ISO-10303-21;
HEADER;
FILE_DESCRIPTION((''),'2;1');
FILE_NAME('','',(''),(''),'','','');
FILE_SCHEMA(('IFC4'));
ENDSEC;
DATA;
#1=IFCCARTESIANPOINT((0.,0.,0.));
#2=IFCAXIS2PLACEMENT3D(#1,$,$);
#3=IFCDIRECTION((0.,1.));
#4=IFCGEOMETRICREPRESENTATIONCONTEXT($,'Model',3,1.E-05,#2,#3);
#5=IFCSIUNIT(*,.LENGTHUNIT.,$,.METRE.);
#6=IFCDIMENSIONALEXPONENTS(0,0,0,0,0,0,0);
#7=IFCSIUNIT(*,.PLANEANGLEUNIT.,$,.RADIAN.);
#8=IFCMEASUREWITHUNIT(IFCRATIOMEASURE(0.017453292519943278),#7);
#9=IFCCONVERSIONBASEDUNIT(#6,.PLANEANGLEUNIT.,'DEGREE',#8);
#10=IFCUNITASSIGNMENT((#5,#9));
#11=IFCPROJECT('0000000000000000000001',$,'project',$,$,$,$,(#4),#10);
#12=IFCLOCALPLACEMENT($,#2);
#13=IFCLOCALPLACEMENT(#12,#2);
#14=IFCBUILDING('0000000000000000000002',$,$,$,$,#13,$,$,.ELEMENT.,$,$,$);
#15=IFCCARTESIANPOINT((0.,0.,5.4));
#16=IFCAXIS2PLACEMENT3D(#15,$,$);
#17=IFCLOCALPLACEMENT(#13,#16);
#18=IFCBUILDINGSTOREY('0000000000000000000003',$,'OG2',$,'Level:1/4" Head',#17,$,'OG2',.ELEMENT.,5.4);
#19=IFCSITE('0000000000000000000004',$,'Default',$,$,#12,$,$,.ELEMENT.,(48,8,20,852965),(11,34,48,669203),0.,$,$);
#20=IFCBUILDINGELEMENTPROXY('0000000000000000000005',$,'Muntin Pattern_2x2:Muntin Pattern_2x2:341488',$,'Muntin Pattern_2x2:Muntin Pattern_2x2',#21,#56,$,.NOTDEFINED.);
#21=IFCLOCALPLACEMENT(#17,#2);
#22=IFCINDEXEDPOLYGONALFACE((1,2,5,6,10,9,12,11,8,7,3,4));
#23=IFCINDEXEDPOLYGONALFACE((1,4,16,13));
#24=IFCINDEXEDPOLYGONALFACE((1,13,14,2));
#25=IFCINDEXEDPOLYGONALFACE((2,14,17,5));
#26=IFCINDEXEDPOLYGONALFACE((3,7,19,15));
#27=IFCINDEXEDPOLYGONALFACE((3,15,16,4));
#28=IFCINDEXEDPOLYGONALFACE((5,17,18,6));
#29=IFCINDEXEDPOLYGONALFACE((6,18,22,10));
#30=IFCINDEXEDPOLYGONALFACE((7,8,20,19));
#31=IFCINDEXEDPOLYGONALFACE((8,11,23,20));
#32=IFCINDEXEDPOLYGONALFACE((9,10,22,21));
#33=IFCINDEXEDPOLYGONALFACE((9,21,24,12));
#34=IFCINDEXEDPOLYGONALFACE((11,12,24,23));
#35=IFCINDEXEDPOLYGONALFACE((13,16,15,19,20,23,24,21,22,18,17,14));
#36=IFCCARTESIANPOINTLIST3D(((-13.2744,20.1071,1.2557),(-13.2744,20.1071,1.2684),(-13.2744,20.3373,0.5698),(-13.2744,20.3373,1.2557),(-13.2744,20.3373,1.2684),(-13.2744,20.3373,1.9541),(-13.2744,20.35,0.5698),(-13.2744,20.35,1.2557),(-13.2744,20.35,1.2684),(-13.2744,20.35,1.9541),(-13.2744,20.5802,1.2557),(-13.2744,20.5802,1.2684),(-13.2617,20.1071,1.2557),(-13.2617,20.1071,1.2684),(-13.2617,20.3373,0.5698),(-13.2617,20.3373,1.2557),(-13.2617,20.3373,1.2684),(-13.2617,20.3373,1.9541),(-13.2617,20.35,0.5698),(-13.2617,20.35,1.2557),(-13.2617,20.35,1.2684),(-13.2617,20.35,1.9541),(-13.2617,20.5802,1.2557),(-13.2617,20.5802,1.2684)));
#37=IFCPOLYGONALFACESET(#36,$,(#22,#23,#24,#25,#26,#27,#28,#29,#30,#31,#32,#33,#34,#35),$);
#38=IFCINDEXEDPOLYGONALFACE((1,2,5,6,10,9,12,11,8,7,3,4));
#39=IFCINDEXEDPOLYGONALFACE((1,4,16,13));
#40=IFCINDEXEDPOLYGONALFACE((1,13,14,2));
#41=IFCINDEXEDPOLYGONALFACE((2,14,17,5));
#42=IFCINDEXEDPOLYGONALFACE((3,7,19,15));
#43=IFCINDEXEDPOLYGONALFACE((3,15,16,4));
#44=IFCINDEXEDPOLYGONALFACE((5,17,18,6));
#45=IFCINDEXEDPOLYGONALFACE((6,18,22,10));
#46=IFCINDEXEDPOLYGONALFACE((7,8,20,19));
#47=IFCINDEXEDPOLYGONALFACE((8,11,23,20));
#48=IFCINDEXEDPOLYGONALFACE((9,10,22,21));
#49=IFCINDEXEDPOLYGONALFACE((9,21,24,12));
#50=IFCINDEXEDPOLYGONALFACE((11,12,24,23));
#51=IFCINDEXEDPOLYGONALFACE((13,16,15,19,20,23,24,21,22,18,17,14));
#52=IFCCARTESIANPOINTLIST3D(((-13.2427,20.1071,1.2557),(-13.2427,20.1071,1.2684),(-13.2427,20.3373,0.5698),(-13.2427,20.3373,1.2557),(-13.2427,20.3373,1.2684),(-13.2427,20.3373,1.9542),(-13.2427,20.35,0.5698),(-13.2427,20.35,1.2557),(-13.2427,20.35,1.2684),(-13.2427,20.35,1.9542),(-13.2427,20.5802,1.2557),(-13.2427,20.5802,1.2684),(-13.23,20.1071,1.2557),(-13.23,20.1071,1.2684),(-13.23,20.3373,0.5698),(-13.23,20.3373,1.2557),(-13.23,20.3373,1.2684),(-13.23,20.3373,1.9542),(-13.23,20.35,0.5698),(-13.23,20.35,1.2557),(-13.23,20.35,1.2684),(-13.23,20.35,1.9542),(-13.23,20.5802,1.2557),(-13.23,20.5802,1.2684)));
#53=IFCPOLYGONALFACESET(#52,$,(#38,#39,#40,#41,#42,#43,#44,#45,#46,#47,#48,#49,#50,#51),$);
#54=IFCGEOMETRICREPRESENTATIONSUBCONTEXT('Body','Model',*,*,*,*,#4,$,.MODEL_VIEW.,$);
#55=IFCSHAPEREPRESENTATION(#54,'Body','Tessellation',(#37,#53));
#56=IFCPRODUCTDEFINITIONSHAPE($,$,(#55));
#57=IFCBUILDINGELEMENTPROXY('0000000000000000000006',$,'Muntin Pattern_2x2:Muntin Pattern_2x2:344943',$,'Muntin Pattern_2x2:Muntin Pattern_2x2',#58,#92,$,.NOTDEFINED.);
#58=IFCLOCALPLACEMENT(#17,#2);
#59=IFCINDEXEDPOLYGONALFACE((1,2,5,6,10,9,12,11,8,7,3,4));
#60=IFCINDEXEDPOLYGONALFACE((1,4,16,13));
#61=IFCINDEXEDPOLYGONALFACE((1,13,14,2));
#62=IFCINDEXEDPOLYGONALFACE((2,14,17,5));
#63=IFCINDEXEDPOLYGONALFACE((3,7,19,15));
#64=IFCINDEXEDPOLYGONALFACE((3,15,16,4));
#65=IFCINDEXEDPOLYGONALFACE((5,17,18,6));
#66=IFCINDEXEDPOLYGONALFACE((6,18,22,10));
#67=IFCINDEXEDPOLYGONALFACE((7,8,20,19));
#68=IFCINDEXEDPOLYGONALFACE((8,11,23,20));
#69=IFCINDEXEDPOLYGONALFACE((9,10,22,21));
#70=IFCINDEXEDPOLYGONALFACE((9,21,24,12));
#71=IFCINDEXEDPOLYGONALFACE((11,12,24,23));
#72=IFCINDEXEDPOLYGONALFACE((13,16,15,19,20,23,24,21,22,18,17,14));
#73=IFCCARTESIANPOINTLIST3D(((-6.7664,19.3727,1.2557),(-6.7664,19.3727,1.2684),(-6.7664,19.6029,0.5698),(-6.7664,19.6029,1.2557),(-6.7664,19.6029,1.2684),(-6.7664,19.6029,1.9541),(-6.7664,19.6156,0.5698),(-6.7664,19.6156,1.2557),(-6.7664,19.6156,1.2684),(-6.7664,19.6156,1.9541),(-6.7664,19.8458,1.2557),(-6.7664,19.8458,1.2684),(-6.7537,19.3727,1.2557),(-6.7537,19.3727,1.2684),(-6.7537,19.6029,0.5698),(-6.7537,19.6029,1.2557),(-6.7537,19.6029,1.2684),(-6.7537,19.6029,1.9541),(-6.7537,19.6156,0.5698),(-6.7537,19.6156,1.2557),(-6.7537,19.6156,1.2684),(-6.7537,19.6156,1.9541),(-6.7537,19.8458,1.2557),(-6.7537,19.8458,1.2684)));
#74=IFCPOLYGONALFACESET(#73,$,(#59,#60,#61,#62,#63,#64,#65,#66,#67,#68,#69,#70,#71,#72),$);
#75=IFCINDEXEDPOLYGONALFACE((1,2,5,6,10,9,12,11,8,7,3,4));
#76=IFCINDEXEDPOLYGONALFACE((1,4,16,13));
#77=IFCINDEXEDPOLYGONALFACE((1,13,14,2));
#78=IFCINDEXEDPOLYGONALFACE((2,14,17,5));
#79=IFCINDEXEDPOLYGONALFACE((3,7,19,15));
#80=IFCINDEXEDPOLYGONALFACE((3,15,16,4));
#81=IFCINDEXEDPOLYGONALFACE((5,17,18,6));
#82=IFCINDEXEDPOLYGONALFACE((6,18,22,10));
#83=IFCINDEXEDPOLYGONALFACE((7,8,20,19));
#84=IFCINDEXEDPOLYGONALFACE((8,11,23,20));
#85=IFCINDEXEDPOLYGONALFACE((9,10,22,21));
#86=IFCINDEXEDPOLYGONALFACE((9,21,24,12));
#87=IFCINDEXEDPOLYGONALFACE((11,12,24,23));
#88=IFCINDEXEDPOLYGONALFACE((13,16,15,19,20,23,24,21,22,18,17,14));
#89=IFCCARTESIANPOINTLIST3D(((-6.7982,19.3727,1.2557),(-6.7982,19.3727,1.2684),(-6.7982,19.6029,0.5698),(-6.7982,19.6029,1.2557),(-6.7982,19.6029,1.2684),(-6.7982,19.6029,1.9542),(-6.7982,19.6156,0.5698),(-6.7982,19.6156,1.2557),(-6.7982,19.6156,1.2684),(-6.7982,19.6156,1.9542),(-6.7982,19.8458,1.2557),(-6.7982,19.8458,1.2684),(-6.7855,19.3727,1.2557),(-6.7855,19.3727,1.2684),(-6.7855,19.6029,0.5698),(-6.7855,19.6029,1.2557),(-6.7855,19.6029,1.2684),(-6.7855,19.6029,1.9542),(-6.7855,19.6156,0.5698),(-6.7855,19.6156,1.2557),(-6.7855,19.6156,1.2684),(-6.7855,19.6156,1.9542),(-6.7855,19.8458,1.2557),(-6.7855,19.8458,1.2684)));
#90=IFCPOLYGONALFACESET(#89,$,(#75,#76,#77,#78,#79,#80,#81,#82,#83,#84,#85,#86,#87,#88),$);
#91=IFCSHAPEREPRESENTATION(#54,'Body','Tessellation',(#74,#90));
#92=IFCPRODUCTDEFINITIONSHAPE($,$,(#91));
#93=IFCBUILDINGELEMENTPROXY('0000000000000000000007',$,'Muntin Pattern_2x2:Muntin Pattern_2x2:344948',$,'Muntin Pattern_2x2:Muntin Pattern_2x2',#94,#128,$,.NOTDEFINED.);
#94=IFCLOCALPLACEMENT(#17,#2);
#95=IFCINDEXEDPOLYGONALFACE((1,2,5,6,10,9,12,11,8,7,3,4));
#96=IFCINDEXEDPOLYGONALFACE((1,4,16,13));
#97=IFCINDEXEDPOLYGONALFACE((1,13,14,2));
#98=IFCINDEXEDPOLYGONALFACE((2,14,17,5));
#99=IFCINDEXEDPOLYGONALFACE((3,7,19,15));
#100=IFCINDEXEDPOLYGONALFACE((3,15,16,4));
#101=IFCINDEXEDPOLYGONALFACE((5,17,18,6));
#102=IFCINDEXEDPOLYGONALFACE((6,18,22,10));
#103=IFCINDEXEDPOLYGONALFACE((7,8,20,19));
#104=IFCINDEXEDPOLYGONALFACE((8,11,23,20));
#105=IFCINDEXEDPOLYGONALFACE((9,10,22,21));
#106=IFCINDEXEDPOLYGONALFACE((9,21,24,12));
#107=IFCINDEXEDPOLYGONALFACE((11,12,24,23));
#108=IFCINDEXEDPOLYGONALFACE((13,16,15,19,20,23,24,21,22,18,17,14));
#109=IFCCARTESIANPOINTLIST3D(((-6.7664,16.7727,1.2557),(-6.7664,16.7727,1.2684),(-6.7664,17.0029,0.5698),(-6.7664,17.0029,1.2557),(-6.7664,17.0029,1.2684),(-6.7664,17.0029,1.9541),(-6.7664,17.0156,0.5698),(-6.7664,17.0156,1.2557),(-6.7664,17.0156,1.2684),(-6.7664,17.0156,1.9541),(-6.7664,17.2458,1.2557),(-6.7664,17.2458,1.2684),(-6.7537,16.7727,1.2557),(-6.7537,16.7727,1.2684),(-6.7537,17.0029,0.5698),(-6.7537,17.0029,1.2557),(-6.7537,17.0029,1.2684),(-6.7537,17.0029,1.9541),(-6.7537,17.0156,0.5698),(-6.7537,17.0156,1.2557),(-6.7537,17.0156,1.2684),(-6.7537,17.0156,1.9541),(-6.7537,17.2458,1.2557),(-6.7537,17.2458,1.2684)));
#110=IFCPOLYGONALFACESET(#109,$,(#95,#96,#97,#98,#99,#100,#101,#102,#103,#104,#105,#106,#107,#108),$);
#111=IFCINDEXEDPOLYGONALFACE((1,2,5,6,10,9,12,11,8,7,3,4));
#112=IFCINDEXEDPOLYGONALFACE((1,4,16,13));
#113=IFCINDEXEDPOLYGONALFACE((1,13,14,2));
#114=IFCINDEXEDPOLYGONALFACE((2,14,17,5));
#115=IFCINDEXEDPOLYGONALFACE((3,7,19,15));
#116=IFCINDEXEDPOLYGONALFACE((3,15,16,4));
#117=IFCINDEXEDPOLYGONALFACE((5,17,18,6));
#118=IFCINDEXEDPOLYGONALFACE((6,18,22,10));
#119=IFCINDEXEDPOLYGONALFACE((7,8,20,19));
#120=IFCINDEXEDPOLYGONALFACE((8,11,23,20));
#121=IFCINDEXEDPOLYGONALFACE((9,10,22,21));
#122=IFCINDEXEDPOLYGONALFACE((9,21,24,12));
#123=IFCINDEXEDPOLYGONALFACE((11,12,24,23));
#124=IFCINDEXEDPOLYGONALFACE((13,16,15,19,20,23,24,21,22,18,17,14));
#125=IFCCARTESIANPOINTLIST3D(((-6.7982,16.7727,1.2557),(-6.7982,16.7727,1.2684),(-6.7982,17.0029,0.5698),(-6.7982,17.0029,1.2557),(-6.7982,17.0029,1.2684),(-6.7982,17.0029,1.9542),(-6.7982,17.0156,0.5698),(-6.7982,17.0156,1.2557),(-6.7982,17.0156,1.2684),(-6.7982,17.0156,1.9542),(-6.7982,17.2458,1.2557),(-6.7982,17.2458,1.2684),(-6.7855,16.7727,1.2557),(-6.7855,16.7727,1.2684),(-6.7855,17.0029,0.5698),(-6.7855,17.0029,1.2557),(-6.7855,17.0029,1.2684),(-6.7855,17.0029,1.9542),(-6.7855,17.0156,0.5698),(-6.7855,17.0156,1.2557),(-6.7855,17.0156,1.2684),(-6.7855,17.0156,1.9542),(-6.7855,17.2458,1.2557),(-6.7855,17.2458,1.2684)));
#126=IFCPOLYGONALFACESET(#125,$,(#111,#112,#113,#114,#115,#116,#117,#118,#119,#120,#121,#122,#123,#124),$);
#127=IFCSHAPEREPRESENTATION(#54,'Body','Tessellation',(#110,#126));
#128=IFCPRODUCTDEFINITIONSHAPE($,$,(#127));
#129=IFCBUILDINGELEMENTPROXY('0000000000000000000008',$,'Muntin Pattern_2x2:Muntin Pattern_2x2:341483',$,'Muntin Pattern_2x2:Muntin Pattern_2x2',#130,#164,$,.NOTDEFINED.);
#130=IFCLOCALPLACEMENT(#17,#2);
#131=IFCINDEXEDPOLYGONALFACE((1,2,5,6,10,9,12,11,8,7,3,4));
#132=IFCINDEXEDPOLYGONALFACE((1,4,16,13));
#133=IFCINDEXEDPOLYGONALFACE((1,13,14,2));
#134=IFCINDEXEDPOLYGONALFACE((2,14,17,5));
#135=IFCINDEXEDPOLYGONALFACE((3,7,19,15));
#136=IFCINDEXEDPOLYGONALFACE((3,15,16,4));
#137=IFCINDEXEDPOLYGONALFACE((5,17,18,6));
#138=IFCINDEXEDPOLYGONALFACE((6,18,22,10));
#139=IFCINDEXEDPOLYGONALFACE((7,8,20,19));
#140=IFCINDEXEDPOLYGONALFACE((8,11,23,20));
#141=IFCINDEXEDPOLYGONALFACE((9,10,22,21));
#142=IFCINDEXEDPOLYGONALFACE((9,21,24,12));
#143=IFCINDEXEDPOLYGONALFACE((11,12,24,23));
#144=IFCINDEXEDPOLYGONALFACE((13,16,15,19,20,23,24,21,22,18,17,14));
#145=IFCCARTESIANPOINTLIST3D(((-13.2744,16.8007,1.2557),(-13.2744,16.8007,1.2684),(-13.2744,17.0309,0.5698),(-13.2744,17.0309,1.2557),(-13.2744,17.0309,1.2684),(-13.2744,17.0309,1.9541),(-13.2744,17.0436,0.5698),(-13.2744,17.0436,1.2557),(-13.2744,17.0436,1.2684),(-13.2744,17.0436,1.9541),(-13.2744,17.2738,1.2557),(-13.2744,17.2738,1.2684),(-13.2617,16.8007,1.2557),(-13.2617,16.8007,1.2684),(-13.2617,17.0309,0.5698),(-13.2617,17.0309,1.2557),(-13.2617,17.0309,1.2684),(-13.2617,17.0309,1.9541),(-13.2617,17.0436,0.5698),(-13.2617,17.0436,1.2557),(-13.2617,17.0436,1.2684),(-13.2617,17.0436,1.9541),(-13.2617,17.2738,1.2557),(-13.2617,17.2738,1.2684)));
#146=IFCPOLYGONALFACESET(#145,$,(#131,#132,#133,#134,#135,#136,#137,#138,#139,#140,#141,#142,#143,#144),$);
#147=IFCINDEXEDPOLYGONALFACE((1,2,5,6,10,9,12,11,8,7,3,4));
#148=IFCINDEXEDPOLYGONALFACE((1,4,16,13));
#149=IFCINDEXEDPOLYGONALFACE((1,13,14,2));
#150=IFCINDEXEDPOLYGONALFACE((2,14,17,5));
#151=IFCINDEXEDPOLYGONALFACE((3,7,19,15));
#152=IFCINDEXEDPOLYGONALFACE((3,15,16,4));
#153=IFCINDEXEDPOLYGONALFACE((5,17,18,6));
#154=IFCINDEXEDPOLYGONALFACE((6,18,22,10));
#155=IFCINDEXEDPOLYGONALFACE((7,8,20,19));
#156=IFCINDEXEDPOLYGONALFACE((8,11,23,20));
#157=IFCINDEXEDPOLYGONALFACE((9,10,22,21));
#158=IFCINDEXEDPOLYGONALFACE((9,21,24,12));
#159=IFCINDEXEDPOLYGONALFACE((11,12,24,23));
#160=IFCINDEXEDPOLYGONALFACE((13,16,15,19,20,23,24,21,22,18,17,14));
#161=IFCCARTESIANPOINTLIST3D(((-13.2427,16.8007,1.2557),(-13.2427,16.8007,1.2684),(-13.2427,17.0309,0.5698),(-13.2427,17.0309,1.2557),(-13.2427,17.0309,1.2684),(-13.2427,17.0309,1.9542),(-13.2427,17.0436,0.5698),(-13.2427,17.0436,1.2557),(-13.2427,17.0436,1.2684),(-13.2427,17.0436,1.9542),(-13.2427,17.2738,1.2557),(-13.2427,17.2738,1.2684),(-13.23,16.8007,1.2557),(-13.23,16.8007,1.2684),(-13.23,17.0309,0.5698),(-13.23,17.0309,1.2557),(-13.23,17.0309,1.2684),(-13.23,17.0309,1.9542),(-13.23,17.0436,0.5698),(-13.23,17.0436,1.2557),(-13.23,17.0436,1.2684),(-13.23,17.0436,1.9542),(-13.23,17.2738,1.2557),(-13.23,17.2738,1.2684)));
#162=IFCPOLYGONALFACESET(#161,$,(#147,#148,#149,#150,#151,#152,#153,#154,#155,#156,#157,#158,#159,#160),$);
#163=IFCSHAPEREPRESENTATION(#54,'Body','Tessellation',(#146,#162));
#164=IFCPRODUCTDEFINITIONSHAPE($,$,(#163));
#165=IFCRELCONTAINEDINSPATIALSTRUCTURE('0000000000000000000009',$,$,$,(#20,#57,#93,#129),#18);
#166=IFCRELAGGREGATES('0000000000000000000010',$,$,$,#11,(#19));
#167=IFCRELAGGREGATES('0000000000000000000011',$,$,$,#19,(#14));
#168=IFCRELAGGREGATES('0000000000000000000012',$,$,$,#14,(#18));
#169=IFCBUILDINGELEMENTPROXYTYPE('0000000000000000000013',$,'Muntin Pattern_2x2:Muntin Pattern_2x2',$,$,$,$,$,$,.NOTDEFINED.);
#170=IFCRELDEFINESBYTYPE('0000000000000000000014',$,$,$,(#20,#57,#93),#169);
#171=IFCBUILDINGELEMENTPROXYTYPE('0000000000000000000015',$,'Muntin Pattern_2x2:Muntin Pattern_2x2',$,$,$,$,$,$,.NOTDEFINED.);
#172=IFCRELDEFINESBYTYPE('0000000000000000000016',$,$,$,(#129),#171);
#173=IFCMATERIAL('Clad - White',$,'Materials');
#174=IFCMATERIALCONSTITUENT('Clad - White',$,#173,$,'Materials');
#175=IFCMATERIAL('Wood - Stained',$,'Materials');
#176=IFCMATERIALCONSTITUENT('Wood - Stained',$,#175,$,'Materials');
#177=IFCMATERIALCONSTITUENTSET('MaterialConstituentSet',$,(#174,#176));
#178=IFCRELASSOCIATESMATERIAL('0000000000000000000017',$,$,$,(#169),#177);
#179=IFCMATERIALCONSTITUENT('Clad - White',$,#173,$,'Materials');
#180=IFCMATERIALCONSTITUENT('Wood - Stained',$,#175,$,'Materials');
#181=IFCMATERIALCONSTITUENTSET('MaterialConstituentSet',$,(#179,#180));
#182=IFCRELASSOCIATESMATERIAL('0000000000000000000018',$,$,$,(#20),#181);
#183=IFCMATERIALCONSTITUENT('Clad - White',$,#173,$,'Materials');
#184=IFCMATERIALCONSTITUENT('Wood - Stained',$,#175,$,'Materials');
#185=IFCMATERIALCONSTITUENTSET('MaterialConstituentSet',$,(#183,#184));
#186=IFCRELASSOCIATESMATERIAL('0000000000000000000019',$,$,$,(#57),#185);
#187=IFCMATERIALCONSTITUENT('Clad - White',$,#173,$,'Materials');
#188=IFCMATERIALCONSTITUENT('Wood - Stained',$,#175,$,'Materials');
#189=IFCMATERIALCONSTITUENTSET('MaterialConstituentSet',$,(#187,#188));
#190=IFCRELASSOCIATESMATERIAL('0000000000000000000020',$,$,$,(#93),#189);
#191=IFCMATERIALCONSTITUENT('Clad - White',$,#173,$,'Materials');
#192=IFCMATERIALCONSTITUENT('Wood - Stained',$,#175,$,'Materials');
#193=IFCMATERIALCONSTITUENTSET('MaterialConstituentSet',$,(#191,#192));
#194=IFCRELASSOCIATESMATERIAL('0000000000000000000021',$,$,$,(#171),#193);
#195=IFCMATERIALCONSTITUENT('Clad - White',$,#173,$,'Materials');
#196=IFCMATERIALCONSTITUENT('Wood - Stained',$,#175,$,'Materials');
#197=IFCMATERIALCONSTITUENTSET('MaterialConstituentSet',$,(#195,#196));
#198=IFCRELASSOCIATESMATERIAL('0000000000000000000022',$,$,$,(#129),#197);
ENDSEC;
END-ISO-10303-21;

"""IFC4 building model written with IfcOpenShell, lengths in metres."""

from ifc_helpers import new_model, entity, si_unit, converted_unit, direction, frame, origin, place, context, subcontext, project, spatial, indexed_curve, outline, extrude, source, transform, mapped, material, constituent, constituent_set, type_object, type_shapes, element, save


model = new_model("IFC4")

# Units and contexts
model_context = context("Model", 3, precision=1e-05, world=origin(), true_north=direction((0.0, 1.0)))
body_context = subcontext(model_context, "Body", "Model", "MODEL_VIEW")
ifc_project = project(units=[si_unit("LENGTHUNIT", "METRE"), converted_unit("PLANEANGLEUNIT", "DEGREE", entity("IfcRatioMeasure", 0.017453292519943278), si_unit("PLANEANGLEUNIT", "RADIAN"), dimensions=[0, 0, 0, 0, 0, 0, 0])], contexts=[model_context])

# Site, building, storey
site_placement = place(None, origin())
site = spatial("IfcSite", under=ifc_project, at=site_placement, Name="Default", CompositionType="ELEMENT", RefLatitude=(48, 8, 20, 852965), RefLongitude=(11, 34, 48, 669203), RefElevation=0.0)
building_placement = place(site_placement, origin())
building = spatial("IfcBuilding", under=site, at=building_placement, CompositionType="ELEMENT")
storey_placement = place(building_placement, frame((0.0, 0.0, 5.4)))
storey = spatial("IfcBuildingStorey", under=building, at=storey_placement, Name="OG2", ObjectType="Level:1/4\" Head", LongName="OG2", CompositionType="ELEMENT", Elevation=5.4)

# Building element proxies
ifc_material_1 = material(Name="Clad - White", Category="Materials")
ifc_material_2 = material(Name="Wood - Stained", Category="Materials")
ifc_constituent_1 = constituent(ifc_material_1, Name="Clad - White", Category="Materials")
ifc_constituent_2 = constituent(ifc_material_2, Name="Wood - Stained", Category="Materials")
ifc_constituent_set_1 = constituent_set(constituents=[ifc_constituent_1, ifc_constituent_2], Name="MaterialConstituentSet")
building_element_proxy_type_1 = type_object("IfcBuildingElementProxyType", Name="Muntin Pattern_2x2:Muntin Pattern_2x2", PredefinedType="NOTDEFINED", material=ifc_constituent_set_1)
shared_shape_1 = source(origin(), body_context, "Body", "SweptSolid", [
    extrude(outline(indexed_curve([(0.0064, -0.0064), (0.6921, -0.0064), (0.6921, 0.0063), (0.0064, 0.0063), (0.0064, 0.2365), (-0.0063, 0.2365), (-0.0063, 0.0063), (-0.6922, 0.0063), (-0.6922, -0.0064), (-0.0063, -0.0064), (-0.0063, -0.2365), (0.0064, -0.2365), (0.0064, -0.0064)], self_intersect=False)), frame((0.0, -0.0222, 0.6921), z_axis=(0.0, 1.0, 0.0), x_axis=(0.0, 0.0, 1.0)), (0.0, 0.0, 1.0), 0.0127),
    extrude(outline(indexed_curve([(0.0064, -0.0064), (0.6922, -0.0064), (0.6922, 0.0063), (0.0064, 0.0063), (0.0064, 0.2365), (-0.0063, 0.2365), (-0.0063, 0.0063), (-0.6922, 0.0063), (-0.6922, -0.0064), (-0.0063, -0.0064), (-0.0063, -0.2365), (0.0064, -0.2365), (0.0064, -0.0064)], self_intersect=False)), frame((0.0, 0.0095, 0.6922), z_axis=(0.0, 1.0, 0.0), x_axis=(0.0, 0.0, 1.0)), (0.0, 0.0, 1.0), 0.0127),
])
type_shapes(building_element_proxy_type_1, [shared_shape_1])
ifc_constituent_3 = constituent(ifc_material_1, Name="Clad - White", Category="Materials")
ifc_constituent_4 = constituent(ifc_material_2, Name="Wood - Stained", Category="Materials")
ifc_constituent_set_2 = constituent_set(constituents=[ifc_constituent_3, ifc_constituent_4], Name="MaterialConstituentSet")
proxy_1_placement = place(storey_placement, frame((-13.2522, 20.3437, 0.5699), z_axis=(0.0, 0.0, 1.0), x_axis=(0.0, -1.0, 0.0)))
element("IfcBuildingElementProxy", 1, at=proxy_1_placement, inside=storey, type_object=building_element_proxy_type_1, material=ifc_constituent_set_2, Name="Muntin Pattern_2x2:Muntin Pattern_2x2:341488", ObjectType="Muntin Pattern_2x2:Muntin Pattern_2x2", PredefinedType="NOTDEFINED", context=body_context, shape_type="MappedRepresentation", body=[
    mapped(shared_shape_1, transform((0.0, 0.0, 0.0), scale=1.0)),
])
ifc_constituent_5 = constituent(ifc_material_1, Name="Clad - White", Category="Materials")
ifc_constituent_6 = constituent(ifc_material_2, Name="Wood - Stained", Category="Materials")
ifc_constituent_set_3 = constituent_set(constituents=[ifc_constituent_5, ifc_constituent_6], Name="MaterialConstituentSet")
proxy_2_placement = place(storey_placement, frame((-6.7759, 19.6093, 0.5699), z_axis=(0.0, 0.0, 1.0), x_axis=(0.0, 1.0, 0.0)))
element("IfcBuildingElementProxy", 2, at=proxy_2_placement, inside=storey, type_object=building_element_proxy_type_1, material=ifc_constituent_set_3, Name="Muntin Pattern_2x2:Muntin Pattern_2x2:344943", ObjectType="Muntin Pattern_2x2:Muntin Pattern_2x2", PredefinedType="NOTDEFINED", context=body_context, shape_type="MappedRepresentation", body=[
    mapped(shared_shape_1, transform((0.0, 0.0, 0.0), scale=1.0)),
])
ifc_constituent_7 = constituent(ifc_material_1, Name="Clad - White", Category="Materials")
ifc_constituent_8 = constituent(ifc_material_2, Name="Wood - Stained", Category="Materials")
ifc_constituent_set_4 = constituent_set(constituents=[ifc_constituent_7, ifc_constituent_8], Name="MaterialConstituentSet")
proxy_3_placement = place(storey_placement, frame((-6.7759, 17.0093, 0.5699), z_axis=(0.0, 0.0, 1.0), x_axis=(0.0, 1.0, 0.0)))
element("IfcBuildingElementProxy", 3, at=proxy_3_placement, inside=storey, type_object=building_element_proxy_type_1, material=ifc_constituent_set_4, Name="Muntin Pattern_2x2:Muntin Pattern_2x2:344948", ObjectType="Muntin Pattern_2x2:Muntin Pattern_2x2", PredefinedType="NOTDEFINED", context=body_context, shape_type="MappedRepresentation", body=[
    mapped(shared_shape_1, transform((0.0, 0.0, 0.0), scale=1.0)),
])
ifc_constituent_9 = constituent(ifc_material_1, Name="Clad - White", Category="Materials")
ifc_constituent_10 = constituent(ifc_material_2, Name="Wood - Stained", Category="Materials")
ifc_constituent_set_5 = constituent_set(constituents=[ifc_constituent_9, ifc_constituent_10], Name="MaterialConstituentSet")
ifc_constituent_11 = constituent(ifc_material_1, Name="Clad - White", Category="Materials")
ifc_constituent_12 = constituent(ifc_material_2, Name="Wood - Stained", Category="Materials")
ifc_constituent_set_6 = constituent_set(constituents=[ifc_constituent_11, ifc_constituent_12], Name="MaterialConstituentSet")
building_element_proxy_type_2 = type_object("IfcBuildingElementProxyType", Name="Muntin Pattern_2x2:Muntin Pattern_2x2", PredefinedType="NOTDEFINED", material=ifc_constituent_set_6)
shared_shape_2 = source(origin(), body_context, "Body", "SweptSolid", [
    extrude(outline(indexed_curve([(0.0064, -0.0064), (0.6921, -0.0064), (0.6921, 0.0063), (0.0064, 0.0063), (0.0064, 0.2365), (-0.0063, 0.2365), (-0.0063, 0.0063), (-0.6922, 0.0063), (-0.6922, -0.0064), (-0.0063, -0.0064), (-0.0063, -0.2365), (0.0064, -0.2365), (0.0064, -0.0064)], self_intersect=False)), frame((0.0, 0.0095, 0.6921), z_axis=(0.0, 1.0, 0.0), x_axis=(0.0, 0.0, 1.0)), (0.0, 0.0, 1.0), 0.0127),
    extrude(outline(indexed_curve([(0.0064, -0.0064), (0.6922, -0.0064), (0.6922, 0.0063), (0.0064, 0.0063), (0.0064, 0.2365), (-0.0063, 0.2365), (-0.0063, 0.0063), (-0.6922, 0.0063), (-0.6922, -0.0064), (-0.0063, -0.0064), (-0.0063, -0.2365), (0.0064, -0.2365), (0.0064, -0.0064)], self_intersect=False)), frame((0.0, -0.0222, 0.6922), z_axis=(0.0, 1.0, 0.0), x_axis=(0.0, 0.0, 1.0)), (0.0, 0.0, 1.0), 0.0127),
])
type_shapes(building_element_proxy_type_2, [shared_shape_2])
proxy_4_placement = place(storey_placement, frame((-13.2522, 17.0372, 0.5699), z_axis=(0.0, 0.0, 1.0), x_axis=(0.0, 1.0, 0.0)))
element("IfcBuildingElementProxy", 4, at=proxy_4_placement, inside=storey, type_object=building_element_proxy_type_2, material=ifc_constituent_set_5, Name="Muntin Pattern_2x2:Muntin Pattern_2x2:341483", ObjectType="Muntin Pattern_2x2:Muntin Pattern_2x2", PredefinedType="NOTDEFINED", context=body_context, shape_type="MappedRepresentation", body=[
    mapped(shared_shape_2, transform((0.0, 0.0, 0.0), scale=1.0)),
])

save(model, "model.ifc")
